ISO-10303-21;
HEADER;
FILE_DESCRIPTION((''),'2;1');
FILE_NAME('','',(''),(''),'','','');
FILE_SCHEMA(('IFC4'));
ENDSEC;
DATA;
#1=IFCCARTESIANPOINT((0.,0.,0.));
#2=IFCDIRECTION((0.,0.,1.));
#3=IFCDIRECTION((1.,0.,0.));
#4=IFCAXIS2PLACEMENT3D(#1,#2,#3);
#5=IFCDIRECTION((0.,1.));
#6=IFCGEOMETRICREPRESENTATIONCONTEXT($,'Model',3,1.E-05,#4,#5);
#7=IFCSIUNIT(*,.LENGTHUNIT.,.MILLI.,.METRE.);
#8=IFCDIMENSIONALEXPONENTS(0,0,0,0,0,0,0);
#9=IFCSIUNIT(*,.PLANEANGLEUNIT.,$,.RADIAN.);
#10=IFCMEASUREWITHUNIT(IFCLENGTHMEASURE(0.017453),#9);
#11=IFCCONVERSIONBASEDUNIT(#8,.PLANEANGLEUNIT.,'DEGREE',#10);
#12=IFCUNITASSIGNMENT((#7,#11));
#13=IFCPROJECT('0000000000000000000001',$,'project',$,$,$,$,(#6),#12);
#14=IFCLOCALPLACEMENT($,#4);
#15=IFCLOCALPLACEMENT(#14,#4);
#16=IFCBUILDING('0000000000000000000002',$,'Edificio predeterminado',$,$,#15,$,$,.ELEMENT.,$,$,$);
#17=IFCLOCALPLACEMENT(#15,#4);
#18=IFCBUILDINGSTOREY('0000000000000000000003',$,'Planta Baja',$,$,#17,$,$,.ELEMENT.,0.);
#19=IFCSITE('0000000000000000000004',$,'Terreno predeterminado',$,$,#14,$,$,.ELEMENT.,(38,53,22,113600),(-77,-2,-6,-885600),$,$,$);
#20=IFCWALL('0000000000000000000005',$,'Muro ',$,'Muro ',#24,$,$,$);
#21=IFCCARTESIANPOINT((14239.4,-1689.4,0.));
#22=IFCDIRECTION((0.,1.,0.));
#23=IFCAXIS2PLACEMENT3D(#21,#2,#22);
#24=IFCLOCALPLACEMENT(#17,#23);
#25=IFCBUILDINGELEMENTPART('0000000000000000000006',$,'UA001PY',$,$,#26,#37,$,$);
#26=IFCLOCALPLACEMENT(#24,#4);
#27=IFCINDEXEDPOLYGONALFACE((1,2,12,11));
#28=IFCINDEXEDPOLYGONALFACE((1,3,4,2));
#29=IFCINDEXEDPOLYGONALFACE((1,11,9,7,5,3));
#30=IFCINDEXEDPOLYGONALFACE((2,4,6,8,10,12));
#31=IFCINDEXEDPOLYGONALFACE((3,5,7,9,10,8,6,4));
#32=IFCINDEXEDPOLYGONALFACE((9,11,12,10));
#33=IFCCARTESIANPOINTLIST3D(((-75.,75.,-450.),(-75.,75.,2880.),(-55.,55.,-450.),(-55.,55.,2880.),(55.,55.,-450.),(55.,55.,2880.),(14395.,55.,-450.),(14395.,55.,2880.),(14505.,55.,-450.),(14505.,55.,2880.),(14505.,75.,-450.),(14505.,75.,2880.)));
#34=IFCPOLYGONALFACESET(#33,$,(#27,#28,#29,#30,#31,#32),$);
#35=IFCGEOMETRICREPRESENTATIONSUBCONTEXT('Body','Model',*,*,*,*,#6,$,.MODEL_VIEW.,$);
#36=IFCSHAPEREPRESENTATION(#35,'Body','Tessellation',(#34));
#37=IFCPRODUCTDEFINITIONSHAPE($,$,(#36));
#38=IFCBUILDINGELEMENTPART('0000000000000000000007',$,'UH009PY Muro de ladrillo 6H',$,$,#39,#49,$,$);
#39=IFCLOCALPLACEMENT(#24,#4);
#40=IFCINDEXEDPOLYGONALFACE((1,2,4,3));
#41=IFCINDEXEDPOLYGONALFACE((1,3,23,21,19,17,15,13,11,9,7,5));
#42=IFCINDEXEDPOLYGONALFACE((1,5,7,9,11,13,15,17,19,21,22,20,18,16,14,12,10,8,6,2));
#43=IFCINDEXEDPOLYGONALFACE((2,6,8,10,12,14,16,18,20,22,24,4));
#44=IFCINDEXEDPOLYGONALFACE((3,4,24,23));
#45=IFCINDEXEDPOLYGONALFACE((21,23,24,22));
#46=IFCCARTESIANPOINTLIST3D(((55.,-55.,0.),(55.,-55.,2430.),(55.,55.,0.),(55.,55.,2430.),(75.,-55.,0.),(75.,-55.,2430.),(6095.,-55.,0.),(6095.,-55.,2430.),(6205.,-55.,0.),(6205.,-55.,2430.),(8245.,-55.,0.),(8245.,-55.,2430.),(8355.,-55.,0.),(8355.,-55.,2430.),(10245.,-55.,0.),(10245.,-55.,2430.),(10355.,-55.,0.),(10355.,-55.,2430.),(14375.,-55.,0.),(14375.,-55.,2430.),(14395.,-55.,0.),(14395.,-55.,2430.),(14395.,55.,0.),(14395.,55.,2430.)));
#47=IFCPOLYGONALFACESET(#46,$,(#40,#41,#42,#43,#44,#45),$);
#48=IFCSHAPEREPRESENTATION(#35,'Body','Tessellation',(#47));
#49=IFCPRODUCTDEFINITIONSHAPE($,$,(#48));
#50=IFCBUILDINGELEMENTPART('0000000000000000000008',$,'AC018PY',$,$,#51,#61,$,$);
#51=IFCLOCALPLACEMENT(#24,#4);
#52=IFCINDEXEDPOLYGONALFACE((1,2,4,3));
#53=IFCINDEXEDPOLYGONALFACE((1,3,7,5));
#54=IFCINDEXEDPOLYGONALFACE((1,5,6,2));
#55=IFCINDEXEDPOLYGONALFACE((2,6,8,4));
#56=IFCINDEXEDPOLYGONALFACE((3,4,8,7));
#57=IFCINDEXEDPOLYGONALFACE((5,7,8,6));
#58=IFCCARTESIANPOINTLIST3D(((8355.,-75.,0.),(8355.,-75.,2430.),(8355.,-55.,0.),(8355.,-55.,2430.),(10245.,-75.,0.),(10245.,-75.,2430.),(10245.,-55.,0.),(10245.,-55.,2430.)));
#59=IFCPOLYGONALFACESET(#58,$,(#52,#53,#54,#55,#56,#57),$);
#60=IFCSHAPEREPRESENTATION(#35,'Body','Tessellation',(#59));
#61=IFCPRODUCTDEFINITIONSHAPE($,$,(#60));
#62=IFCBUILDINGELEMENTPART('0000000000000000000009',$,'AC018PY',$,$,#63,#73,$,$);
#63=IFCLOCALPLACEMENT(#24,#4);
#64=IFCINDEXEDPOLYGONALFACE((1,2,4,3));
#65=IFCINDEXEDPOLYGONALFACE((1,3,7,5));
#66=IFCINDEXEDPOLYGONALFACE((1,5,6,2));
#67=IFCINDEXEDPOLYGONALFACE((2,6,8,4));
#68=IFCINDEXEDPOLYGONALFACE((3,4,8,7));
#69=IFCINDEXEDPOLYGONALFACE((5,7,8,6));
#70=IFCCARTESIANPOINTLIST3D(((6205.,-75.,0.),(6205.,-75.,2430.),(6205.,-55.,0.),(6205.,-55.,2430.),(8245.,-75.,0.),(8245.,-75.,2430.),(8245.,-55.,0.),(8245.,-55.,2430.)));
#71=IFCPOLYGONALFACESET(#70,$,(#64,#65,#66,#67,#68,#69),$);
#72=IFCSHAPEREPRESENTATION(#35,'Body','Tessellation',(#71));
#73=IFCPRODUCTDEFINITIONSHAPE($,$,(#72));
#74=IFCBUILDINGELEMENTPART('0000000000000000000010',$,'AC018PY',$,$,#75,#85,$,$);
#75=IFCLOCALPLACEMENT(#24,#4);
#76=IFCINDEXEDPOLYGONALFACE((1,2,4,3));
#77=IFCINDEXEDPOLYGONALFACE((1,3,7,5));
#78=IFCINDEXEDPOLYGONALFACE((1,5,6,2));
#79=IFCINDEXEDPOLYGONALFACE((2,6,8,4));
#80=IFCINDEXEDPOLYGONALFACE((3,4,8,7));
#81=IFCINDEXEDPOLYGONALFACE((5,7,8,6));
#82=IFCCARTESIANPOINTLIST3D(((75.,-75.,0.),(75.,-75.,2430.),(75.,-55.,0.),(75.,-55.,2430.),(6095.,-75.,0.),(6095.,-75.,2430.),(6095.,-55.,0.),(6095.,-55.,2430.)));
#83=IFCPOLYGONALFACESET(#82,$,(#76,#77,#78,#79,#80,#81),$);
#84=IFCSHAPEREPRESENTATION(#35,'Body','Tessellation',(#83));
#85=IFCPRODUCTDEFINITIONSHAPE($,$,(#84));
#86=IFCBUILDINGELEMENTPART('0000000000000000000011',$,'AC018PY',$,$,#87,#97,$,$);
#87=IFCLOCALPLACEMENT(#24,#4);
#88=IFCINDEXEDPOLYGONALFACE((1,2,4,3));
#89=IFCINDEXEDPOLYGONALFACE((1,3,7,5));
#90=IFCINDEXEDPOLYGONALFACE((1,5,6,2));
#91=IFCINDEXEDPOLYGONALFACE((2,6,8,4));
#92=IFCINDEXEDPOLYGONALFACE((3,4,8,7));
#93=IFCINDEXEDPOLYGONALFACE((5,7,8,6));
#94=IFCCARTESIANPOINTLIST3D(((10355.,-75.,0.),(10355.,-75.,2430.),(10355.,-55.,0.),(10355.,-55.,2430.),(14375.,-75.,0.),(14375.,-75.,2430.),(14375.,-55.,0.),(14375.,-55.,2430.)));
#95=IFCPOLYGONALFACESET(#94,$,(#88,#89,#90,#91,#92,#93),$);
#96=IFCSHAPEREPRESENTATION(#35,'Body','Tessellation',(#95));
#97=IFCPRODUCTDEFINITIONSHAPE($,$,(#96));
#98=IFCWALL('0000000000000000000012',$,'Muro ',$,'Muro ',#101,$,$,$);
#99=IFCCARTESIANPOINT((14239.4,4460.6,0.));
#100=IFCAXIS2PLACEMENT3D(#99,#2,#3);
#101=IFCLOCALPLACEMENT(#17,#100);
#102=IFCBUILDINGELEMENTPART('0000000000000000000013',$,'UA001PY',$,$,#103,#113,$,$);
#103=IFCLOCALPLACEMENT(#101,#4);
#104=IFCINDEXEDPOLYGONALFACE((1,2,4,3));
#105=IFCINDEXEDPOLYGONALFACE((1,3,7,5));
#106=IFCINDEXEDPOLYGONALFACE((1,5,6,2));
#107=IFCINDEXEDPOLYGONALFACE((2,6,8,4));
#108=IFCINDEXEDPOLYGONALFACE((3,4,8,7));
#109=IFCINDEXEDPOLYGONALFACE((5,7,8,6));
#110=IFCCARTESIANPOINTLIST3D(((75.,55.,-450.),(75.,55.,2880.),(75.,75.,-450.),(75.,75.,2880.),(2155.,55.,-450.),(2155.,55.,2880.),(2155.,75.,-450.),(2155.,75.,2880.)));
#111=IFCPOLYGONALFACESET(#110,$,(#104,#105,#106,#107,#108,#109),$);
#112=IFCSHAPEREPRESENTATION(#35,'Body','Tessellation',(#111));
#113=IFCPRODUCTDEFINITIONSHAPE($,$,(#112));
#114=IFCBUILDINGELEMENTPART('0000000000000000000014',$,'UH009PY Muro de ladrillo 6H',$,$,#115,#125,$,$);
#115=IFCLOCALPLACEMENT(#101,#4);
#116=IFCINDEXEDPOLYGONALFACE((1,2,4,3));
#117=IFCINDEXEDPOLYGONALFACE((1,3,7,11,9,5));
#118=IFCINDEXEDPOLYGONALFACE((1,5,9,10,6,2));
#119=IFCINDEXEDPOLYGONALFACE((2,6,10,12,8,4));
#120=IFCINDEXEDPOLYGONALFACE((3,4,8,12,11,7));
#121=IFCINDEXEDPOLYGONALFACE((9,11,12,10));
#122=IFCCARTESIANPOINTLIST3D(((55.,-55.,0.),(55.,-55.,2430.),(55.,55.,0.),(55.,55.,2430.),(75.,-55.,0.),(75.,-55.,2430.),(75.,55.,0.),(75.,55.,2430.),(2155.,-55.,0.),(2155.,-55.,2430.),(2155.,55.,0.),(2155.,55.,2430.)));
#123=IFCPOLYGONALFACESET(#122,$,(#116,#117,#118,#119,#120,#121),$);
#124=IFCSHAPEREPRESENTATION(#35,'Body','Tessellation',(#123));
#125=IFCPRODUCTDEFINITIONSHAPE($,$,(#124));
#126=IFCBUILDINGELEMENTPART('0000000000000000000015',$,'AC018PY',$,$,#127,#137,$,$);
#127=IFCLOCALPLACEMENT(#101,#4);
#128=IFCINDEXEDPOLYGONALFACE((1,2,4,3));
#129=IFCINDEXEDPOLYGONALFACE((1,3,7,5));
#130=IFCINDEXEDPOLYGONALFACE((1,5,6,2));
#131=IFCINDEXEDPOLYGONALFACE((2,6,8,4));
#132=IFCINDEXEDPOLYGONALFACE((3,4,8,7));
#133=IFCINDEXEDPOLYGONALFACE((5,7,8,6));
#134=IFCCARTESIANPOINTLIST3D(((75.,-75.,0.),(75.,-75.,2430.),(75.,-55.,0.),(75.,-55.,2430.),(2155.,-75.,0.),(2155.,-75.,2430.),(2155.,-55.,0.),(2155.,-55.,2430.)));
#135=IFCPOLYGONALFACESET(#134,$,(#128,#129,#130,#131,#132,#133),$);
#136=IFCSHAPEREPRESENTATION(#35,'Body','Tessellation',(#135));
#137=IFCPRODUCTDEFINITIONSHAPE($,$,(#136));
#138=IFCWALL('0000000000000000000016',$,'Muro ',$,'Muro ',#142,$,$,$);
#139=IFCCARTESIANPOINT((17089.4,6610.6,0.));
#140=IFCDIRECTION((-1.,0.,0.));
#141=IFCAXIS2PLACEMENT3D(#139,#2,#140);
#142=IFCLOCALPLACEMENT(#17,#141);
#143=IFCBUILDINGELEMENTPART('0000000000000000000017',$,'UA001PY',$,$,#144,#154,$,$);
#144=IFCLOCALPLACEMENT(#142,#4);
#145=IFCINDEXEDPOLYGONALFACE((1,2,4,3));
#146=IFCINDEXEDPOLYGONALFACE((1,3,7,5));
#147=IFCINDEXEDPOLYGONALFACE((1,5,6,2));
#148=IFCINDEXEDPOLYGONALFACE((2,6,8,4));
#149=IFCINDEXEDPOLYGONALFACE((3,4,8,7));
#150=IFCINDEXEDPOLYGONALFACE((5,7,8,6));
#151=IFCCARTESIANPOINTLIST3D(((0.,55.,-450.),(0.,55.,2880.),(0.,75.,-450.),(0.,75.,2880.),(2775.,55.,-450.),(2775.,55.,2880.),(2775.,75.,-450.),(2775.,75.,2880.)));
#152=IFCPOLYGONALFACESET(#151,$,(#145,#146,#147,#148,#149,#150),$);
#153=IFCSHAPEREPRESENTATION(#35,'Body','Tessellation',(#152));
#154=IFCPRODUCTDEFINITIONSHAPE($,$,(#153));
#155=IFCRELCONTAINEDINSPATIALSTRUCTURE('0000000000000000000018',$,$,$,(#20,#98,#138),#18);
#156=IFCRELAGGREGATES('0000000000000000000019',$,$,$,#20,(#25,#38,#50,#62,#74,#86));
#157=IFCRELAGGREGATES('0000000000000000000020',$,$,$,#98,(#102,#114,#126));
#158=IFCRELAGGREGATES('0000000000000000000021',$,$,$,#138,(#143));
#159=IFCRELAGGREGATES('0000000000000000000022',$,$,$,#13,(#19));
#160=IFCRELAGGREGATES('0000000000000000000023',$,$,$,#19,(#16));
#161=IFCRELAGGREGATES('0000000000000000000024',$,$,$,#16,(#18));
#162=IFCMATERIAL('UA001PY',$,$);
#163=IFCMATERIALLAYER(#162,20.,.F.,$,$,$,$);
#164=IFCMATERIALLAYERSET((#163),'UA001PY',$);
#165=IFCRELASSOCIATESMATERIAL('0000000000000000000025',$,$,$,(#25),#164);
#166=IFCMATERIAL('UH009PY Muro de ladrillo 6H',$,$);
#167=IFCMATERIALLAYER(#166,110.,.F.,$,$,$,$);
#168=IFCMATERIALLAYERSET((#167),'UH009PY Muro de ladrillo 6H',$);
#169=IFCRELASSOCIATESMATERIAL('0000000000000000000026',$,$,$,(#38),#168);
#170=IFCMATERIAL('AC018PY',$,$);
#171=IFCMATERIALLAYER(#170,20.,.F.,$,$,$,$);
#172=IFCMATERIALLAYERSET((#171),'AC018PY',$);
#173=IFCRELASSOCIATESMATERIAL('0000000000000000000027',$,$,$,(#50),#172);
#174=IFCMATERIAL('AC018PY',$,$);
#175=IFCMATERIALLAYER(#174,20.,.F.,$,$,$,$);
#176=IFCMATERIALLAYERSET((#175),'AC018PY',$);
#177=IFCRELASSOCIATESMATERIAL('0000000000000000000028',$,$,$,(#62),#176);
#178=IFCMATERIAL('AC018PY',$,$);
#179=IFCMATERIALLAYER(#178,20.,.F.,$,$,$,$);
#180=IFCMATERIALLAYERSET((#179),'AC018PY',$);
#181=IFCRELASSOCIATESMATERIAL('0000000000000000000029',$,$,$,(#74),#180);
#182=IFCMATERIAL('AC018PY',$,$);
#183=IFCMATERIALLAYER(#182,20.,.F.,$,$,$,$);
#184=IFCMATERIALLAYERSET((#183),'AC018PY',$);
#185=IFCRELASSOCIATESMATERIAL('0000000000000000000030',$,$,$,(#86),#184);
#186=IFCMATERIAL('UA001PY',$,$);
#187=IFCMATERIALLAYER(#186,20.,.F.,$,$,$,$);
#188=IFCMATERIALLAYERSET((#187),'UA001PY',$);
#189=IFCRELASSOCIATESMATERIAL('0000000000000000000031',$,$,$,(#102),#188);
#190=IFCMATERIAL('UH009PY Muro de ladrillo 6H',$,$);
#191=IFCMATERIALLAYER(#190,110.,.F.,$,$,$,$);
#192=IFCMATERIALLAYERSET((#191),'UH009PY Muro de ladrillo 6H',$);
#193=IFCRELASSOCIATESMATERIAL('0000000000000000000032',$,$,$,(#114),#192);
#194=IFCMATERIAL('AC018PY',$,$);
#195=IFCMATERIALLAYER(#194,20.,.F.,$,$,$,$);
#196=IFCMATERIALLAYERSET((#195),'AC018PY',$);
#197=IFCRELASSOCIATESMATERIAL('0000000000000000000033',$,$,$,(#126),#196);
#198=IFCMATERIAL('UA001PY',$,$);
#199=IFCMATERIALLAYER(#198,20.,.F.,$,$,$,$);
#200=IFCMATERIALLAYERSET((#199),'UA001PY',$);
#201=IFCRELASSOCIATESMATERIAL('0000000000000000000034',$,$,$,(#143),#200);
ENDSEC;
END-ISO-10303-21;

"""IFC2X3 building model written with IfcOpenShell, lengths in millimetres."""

from ifc_helpers import new_model, entity, si_unit, converted_unit, direction, frame, origin_with_axes, place, context, subcontext, project, spatial, polyline, outline, extrude, material, layer, layer_set, layer_usage, element, aggregate, save


model = new_model("IFC2X3")

# Units and contexts
model_context = context("Model", 3, precision=1e-05, world=origin_with_axes(), true_north=direction((0.0, 1.0)))
body_context = subcontext(model_context, "Body", "Model", "MODEL_VIEW")
ifc_project = project(units=[si_unit("LENGTHUNIT", "METRE", prefix="MILLI"), converted_unit("PLANEANGLEUNIT", "DEGREE", entity("IfcLengthMeasure", 0.017453), si_unit("PLANEANGLEUNIT", "RADIAN"), dimensions=[0, 0, 0, 0, 0, 0, 0])], contexts=[model_context])

# Site, building, storey
site_placement = place(None, origin_with_axes())
site = spatial("IfcSite", under=ifc_project, at=site_placement, Name="Terreno predeterminado", CompositionType="ELEMENT", RefLatitude=(38, 53, 22, 113600), RefLongitude=(-77, -2, -6, -885600))
building_placement = place(site_placement, origin_with_axes())
building = spatial("IfcBuilding", under=site, at=building_placement, Name="Edificio predeterminado", CompositionType="ELEMENT")
storey_placement = place(building_placement, origin_with_axes())
storey = spatial("IfcBuildingStorey", under=building, at=storey_placement, Name="Planta Baja", CompositionType="ELEMENT", Elevation=0.0)

# Walls, building element parts
wall_1_placement = place(storey_placement, frame((14239.4, -1689.4, 0.0), z_axis=(0.0, 0.0, 1.0), x_axis=(0.0, 1.0, 0.0)))
wall_1 = element("IfcWall", 1, at=wall_1_placement, inside=storey, Name="Muro ", ObjectType="Muro ")
ifc_material_1 = material(Name="UA001PY")
ifc_layer_1 = layer(ifc_material_1, 20.0, ventilated=False)
ifc_layer_set_1 = layer_set([ifc_layer_1], Name="UA001PY")
ifc_layer_usage_1 = layer_usage(ifc_layer_set_1, "AXIS2", "NEGATIVE", -75.0)
building_element_part_1_placement = place(wall_1_placement, origin_with_axes())
building_element_part_1 = element("IfcBuildingElementPart", 2, at=building_element_part_1_placement, material=ifc_layer_usage_1, Name="UA001PY", context=body_context, shape_type="SweptSolid", body=[
    extrude(outline(polyline([(14505.0, 75.0), (14505.0, 55.0), (14395.0, 55.0), (55.0, 55.0), (-55.0, 55.0), (-75.0, 75.0), (14505.0, 75.0)])), frame((0.0, 0.0, -450.0), z_axis=(0.0, 0.0, 1.0), x_axis=(1.0, 0.0, 0.0)), (0.0, 0.0, 1.0), 3330.0),
])
ifc_material_2 = material(Name="UH009PY Muro de ladrillo 6H")
ifc_layer_2 = layer(ifc_material_2, 110.0, ventilated=False)
ifc_layer_set_2 = layer_set([ifc_layer_2], Name="UH009PY Muro de ladrillo 6H")
ifc_layer_usage_2 = layer_usage(ifc_layer_set_2, "AXIS2", "NEGATIVE", -55.0)
building_element_part_2_placement = place(wall_1_placement, origin_with_axes())
building_element_part_2 = element("IfcBuildingElementPart", 3, at=building_element_part_2_placement, material=ifc_layer_usage_2, Name="UH009PY Muro de ladrillo 6H", context=body_context, shape_type="SweptSolid", body=[
    extrude(outline(polyline([(14395.0, 55.0), (14395.0, -55.0), (14375.0, -55.0), (10355.0, -55.0), (10245.0, -55.0), (8355.0, -55.0), (8245.0, -55.0), (6205.0, -55.0), (6095.0, -55.0), (75.0, -55.0), (55.0, -55.0), (55.0, 55.0), (14395.0, 55.0)])), origin_with_axes(), (0.0, 0.0, 1.0), 2430.0),
])
ifc_material_3 = material(Name="AC018PY")
ifc_layer_3 = layer(ifc_material_3, 20.0, ventilated=False)
ifc_layer_set_3 = layer_set([ifc_layer_3], Name="AC018PY")
ifc_layer_usage_3 = layer_usage(ifc_layer_set_3, "AXIS2", "NEGATIVE", 55.0)
building_element_part_3_placement = place(wall_1_placement, origin_with_axes())
building_element_part_3 = element("IfcBuildingElementPart", 4, at=building_element_part_3_placement, material=ifc_layer_usage_3, Name="AC018PY", context=body_context, shape_type="SweptSolid", body=[
    extrude(outline(polyline([(8355.0, -55.0), (10245.0, -55.0), (10245.0, -75.0), (8355.0, -75.0), (8355.0, -55.0)])), origin_with_axes(), (0.0, 0.0, 1.0), 2430.0),
])
ifc_material_4 = material(Name="AC018PY")
ifc_layer_4 = layer(ifc_material_4, 20.0, ventilated=False)
ifc_layer_set_4 = layer_set([ifc_layer_4], Name="AC018PY")
ifc_layer_usage_4 = layer_usage(ifc_layer_set_4, "AXIS2", "NEGATIVE", 55.0)
building_element_part_4_placement = place(wall_1_placement, origin_with_axes())
building_element_part_4 = element("IfcBuildingElementPart", 5, at=building_element_part_4_placement, material=ifc_layer_usage_4, Name="AC018PY", context=body_context, shape_type="SweptSolid", body=[
    extrude(outline(polyline([(8245.0, -55.0), (8245.0, -75.0), (6205.0, -75.0), (6205.0, -55.0), (8245.0, -55.0)])), origin_with_axes(), (0.0, 0.0, 1.0), 2430.0),
])
ifc_material_5 = material(Name="AC018PY")
ifc_layer_5 = layer(ifc_material_5, 20.0, ventilated=False)
ifc_layer_set_5 = layer_set([ifc_layer_5], Name="AC018PY")
ifc_layer_usage_5 = layer_usage(ifc_layer_set_5, "AXIS2", "NEGATIVE", 55.0)
building_element_part_5_placement = place(wall_1_placement, origin_with_axes())
building_element_part_5 = element("IfcBuildingElementPart", 6, at=building_element_part_5_placement, material=ifc_layer_usage_5, Name="AC018PY", context=body_context, shape_type="SweptSolid", body=[
    extrude(outline(polyline([(6095.0, -55.0), (6095.0, -75.0), (75.0, -75.0), (75.0, -55.0), (6095.0, -55.0)])), origin_with_axes(), (0.0, 0.0, 1.0), 2430.0),
])
ifc_material_6 = material(Name="AC018PY")
ifc_layer_6 = layer(ifc_material_6, 20.0, ventilated=False)
ifc_layer_set_6 = layer_set([ifc_layer_6], Name="AC018PY")
ifc_layer_usage_6 = layer_usage(ifc_layer_set_6, "AXIS2", "NEGATIVE", 55.0)
building_element_part_6_placement = place(wall_1_placement, origin_with_axes())
building_element_part_6 = element("IfcBuildingElementPart", 7, at=building_element_part_6_placement, material=ifc_layer_usage_6, Name="AC018PY", context=body_context, shape_type="SweptSolid", body=[
    extrude(outline(polyline([(14375.0, -55.0), (14375.0, -75.0), (10355.0, -75.0), (10355.0, -55.0), (14375.0, -55.0)])), origin_with_axes(), (0.0, 0.0, 1.0), 2430.0),
])
aggregate(wall_1, [building_element_part_1, building_element_part_2, building_element_part_3, building_element_part_4, building_element_part_5, building_element_part_6])
wall_2_placement = place(storey_placement, frame((14239.4, 4460.6, 0.0), z_axis=(0.0, 0.0, 1.0), x_axis=(1.0, 0.0, 0.0)))
wall_2 = element("IfcWall", 8, at=wall_2_placement, inside=storey, Name="Muro ", ObjectType="Muro ")
ifc_material_7 = material(Name="UA001PY")
ifc_layer_7 = layer(ifc_material_7, 20.0, ventilated=False)
ifc_layer_set_7 = layer_set([ifc_layer_7], Name="UA001PY")
ifc_layer_usage_7 = layer_usage(ifc_layer_set_7, "AXIS2", "NEGATIVE", -75.0)
building_element_part_7_placement = place(wall_2_placement, origin_with_axes())
building_element_part_7 = element("IfcBuildingElementPart", 9, at=building_element_part_7_placement, material=ifc_layer_usage_7, Name="UA001PY", context=body_context, shape_type="SweptSolid", body=[
    extrude(outline(polyline([(2155.0, 75.0), (2155.0, 55.0), (75.0, 55.0), (75.0, 75.0), (2155.0, 75.0)])), frame((0.0, 0.0, -450.0), z_axis=(0.0, 0.0, 1.0), x_axis=(1.0, 0.0, 0.0)), (0.0, 0.0, 1.0), 3330.0),
])
ifc_material_8 = material(Name="UH009PY Muro de ladrillo 6H")
ifc_layer_8 = layer(ifc_material_8, 110.0, ventilated=False)
ifc_layer_set_8 = layer_set([ifc_layer_8], Name="UH009PY Muro de ladrillo 6H")
ifc_layer_usage_8 = layer_usage(ifc_layer_set_8, "AXIS2", "NEGATIVE", -55.0)
building_element_part_8_placement = place(wall_2_placement, origin_with_axes())
building_element_part_8 = element("IfcBuildingElementPart", 10, at=building_element_part_8_placement, material=ifc_layer_usage_8, Name="UH009PY Muro de ladrillo 6H", context=body_context, shape_type="SweptSolid", body=[
    extrude(outline(polyline([(2155.0, 55.0), (2155.0, -55.0), (75.0, -55.0), (55.0, -55.0), (55.0, 55.0), (75.0, 55.0), (2155.0, 55.0)])), origin_with_axes(), (0.0, 0.0, 1.0), 2430.0),
])
ifc_material_9 = material(Name="AC018PY")
ifc_layer_9 = layer(ifc_material_9, 20.0, ventilated=False)
ifc_layer_set_9 = layer_set([ifc_layer_9], Name="AC018PY")
ifc_layer_usage_9 = layer_usage(ifc_layer_set_9, "AXIS2", "NEGATIVE", 55.0)
building_element_part_9_placement = place(wall_2_placement, origin_with_axes())
building_element_part_9 = element("IfcBuildingElementPart", 11, at=building_element_part_9_placement, material=ifc_layer_usage_9, Name="AC018PY", context=body_context, shape_type="SweptSolid", body=[
    extrude(outline(polyline([(2155.0, -55.0), (2155.0, -75.0), (75.0, -75.0), (75.0, -55.0), (2155.0, -55.0)])), origin_with_axes(), (0.0, 0.0, 1.0), 2430.0),
])
aggregate(wall_2, [building_element_part_7, building_element_part_8, building_element_part_9])

# Wall, building element part
wall_3_placement = place(storey_placement, frame((17089.4, 6610.6, 0.0), z_axis=(0.0, 0.0, 1.0), x_axis=(-1.0, 0.0, 0.0)))
wall_3 = element("IfcWall", 12, at=wall_3_placement, inside=storey, Name="Muro ", ObjectType="Muro ")
ifc_material_10 = material(Name="UA001PY")
ifc_layer_10 = layer(ifc_material_10, 20.0, ventilated=False)
ifc_layer_set_10 = layer_set([ifc_layer_10], Name="UA001PY")
ifc_layer_usage_10 = layer_usage(ifc_layer_set_10, "AXIS2", "NEGATIVE", -75.0)
building_element_part_10_placement = place(wall_3_placement, origin_with_axes())
building_element_part_10 = element("IfcBuildingElementPart", 13, at=building_element_part_10_placement, material=ifc_layer_usage_10, Name="UA001PY", context=body_context, shape_type="SweptSolid", body=[
    extrude(outline(polyline([(0.0, 75.0), (2775.0, 75.0), (2775.0, 55.0), (0.0, 55.0), (0.0, 75.0)])), frame((0.0, 0.0, -450.0), z_axis=(0.0, 0.0, 1.0), x_axis=(1.0, 0.0, 0.0)), (0.0, 0.0, 1.0), 3330.0),
])
aggregate(wall_3, [building_element_part_10])

save(model, "model.ifc")
